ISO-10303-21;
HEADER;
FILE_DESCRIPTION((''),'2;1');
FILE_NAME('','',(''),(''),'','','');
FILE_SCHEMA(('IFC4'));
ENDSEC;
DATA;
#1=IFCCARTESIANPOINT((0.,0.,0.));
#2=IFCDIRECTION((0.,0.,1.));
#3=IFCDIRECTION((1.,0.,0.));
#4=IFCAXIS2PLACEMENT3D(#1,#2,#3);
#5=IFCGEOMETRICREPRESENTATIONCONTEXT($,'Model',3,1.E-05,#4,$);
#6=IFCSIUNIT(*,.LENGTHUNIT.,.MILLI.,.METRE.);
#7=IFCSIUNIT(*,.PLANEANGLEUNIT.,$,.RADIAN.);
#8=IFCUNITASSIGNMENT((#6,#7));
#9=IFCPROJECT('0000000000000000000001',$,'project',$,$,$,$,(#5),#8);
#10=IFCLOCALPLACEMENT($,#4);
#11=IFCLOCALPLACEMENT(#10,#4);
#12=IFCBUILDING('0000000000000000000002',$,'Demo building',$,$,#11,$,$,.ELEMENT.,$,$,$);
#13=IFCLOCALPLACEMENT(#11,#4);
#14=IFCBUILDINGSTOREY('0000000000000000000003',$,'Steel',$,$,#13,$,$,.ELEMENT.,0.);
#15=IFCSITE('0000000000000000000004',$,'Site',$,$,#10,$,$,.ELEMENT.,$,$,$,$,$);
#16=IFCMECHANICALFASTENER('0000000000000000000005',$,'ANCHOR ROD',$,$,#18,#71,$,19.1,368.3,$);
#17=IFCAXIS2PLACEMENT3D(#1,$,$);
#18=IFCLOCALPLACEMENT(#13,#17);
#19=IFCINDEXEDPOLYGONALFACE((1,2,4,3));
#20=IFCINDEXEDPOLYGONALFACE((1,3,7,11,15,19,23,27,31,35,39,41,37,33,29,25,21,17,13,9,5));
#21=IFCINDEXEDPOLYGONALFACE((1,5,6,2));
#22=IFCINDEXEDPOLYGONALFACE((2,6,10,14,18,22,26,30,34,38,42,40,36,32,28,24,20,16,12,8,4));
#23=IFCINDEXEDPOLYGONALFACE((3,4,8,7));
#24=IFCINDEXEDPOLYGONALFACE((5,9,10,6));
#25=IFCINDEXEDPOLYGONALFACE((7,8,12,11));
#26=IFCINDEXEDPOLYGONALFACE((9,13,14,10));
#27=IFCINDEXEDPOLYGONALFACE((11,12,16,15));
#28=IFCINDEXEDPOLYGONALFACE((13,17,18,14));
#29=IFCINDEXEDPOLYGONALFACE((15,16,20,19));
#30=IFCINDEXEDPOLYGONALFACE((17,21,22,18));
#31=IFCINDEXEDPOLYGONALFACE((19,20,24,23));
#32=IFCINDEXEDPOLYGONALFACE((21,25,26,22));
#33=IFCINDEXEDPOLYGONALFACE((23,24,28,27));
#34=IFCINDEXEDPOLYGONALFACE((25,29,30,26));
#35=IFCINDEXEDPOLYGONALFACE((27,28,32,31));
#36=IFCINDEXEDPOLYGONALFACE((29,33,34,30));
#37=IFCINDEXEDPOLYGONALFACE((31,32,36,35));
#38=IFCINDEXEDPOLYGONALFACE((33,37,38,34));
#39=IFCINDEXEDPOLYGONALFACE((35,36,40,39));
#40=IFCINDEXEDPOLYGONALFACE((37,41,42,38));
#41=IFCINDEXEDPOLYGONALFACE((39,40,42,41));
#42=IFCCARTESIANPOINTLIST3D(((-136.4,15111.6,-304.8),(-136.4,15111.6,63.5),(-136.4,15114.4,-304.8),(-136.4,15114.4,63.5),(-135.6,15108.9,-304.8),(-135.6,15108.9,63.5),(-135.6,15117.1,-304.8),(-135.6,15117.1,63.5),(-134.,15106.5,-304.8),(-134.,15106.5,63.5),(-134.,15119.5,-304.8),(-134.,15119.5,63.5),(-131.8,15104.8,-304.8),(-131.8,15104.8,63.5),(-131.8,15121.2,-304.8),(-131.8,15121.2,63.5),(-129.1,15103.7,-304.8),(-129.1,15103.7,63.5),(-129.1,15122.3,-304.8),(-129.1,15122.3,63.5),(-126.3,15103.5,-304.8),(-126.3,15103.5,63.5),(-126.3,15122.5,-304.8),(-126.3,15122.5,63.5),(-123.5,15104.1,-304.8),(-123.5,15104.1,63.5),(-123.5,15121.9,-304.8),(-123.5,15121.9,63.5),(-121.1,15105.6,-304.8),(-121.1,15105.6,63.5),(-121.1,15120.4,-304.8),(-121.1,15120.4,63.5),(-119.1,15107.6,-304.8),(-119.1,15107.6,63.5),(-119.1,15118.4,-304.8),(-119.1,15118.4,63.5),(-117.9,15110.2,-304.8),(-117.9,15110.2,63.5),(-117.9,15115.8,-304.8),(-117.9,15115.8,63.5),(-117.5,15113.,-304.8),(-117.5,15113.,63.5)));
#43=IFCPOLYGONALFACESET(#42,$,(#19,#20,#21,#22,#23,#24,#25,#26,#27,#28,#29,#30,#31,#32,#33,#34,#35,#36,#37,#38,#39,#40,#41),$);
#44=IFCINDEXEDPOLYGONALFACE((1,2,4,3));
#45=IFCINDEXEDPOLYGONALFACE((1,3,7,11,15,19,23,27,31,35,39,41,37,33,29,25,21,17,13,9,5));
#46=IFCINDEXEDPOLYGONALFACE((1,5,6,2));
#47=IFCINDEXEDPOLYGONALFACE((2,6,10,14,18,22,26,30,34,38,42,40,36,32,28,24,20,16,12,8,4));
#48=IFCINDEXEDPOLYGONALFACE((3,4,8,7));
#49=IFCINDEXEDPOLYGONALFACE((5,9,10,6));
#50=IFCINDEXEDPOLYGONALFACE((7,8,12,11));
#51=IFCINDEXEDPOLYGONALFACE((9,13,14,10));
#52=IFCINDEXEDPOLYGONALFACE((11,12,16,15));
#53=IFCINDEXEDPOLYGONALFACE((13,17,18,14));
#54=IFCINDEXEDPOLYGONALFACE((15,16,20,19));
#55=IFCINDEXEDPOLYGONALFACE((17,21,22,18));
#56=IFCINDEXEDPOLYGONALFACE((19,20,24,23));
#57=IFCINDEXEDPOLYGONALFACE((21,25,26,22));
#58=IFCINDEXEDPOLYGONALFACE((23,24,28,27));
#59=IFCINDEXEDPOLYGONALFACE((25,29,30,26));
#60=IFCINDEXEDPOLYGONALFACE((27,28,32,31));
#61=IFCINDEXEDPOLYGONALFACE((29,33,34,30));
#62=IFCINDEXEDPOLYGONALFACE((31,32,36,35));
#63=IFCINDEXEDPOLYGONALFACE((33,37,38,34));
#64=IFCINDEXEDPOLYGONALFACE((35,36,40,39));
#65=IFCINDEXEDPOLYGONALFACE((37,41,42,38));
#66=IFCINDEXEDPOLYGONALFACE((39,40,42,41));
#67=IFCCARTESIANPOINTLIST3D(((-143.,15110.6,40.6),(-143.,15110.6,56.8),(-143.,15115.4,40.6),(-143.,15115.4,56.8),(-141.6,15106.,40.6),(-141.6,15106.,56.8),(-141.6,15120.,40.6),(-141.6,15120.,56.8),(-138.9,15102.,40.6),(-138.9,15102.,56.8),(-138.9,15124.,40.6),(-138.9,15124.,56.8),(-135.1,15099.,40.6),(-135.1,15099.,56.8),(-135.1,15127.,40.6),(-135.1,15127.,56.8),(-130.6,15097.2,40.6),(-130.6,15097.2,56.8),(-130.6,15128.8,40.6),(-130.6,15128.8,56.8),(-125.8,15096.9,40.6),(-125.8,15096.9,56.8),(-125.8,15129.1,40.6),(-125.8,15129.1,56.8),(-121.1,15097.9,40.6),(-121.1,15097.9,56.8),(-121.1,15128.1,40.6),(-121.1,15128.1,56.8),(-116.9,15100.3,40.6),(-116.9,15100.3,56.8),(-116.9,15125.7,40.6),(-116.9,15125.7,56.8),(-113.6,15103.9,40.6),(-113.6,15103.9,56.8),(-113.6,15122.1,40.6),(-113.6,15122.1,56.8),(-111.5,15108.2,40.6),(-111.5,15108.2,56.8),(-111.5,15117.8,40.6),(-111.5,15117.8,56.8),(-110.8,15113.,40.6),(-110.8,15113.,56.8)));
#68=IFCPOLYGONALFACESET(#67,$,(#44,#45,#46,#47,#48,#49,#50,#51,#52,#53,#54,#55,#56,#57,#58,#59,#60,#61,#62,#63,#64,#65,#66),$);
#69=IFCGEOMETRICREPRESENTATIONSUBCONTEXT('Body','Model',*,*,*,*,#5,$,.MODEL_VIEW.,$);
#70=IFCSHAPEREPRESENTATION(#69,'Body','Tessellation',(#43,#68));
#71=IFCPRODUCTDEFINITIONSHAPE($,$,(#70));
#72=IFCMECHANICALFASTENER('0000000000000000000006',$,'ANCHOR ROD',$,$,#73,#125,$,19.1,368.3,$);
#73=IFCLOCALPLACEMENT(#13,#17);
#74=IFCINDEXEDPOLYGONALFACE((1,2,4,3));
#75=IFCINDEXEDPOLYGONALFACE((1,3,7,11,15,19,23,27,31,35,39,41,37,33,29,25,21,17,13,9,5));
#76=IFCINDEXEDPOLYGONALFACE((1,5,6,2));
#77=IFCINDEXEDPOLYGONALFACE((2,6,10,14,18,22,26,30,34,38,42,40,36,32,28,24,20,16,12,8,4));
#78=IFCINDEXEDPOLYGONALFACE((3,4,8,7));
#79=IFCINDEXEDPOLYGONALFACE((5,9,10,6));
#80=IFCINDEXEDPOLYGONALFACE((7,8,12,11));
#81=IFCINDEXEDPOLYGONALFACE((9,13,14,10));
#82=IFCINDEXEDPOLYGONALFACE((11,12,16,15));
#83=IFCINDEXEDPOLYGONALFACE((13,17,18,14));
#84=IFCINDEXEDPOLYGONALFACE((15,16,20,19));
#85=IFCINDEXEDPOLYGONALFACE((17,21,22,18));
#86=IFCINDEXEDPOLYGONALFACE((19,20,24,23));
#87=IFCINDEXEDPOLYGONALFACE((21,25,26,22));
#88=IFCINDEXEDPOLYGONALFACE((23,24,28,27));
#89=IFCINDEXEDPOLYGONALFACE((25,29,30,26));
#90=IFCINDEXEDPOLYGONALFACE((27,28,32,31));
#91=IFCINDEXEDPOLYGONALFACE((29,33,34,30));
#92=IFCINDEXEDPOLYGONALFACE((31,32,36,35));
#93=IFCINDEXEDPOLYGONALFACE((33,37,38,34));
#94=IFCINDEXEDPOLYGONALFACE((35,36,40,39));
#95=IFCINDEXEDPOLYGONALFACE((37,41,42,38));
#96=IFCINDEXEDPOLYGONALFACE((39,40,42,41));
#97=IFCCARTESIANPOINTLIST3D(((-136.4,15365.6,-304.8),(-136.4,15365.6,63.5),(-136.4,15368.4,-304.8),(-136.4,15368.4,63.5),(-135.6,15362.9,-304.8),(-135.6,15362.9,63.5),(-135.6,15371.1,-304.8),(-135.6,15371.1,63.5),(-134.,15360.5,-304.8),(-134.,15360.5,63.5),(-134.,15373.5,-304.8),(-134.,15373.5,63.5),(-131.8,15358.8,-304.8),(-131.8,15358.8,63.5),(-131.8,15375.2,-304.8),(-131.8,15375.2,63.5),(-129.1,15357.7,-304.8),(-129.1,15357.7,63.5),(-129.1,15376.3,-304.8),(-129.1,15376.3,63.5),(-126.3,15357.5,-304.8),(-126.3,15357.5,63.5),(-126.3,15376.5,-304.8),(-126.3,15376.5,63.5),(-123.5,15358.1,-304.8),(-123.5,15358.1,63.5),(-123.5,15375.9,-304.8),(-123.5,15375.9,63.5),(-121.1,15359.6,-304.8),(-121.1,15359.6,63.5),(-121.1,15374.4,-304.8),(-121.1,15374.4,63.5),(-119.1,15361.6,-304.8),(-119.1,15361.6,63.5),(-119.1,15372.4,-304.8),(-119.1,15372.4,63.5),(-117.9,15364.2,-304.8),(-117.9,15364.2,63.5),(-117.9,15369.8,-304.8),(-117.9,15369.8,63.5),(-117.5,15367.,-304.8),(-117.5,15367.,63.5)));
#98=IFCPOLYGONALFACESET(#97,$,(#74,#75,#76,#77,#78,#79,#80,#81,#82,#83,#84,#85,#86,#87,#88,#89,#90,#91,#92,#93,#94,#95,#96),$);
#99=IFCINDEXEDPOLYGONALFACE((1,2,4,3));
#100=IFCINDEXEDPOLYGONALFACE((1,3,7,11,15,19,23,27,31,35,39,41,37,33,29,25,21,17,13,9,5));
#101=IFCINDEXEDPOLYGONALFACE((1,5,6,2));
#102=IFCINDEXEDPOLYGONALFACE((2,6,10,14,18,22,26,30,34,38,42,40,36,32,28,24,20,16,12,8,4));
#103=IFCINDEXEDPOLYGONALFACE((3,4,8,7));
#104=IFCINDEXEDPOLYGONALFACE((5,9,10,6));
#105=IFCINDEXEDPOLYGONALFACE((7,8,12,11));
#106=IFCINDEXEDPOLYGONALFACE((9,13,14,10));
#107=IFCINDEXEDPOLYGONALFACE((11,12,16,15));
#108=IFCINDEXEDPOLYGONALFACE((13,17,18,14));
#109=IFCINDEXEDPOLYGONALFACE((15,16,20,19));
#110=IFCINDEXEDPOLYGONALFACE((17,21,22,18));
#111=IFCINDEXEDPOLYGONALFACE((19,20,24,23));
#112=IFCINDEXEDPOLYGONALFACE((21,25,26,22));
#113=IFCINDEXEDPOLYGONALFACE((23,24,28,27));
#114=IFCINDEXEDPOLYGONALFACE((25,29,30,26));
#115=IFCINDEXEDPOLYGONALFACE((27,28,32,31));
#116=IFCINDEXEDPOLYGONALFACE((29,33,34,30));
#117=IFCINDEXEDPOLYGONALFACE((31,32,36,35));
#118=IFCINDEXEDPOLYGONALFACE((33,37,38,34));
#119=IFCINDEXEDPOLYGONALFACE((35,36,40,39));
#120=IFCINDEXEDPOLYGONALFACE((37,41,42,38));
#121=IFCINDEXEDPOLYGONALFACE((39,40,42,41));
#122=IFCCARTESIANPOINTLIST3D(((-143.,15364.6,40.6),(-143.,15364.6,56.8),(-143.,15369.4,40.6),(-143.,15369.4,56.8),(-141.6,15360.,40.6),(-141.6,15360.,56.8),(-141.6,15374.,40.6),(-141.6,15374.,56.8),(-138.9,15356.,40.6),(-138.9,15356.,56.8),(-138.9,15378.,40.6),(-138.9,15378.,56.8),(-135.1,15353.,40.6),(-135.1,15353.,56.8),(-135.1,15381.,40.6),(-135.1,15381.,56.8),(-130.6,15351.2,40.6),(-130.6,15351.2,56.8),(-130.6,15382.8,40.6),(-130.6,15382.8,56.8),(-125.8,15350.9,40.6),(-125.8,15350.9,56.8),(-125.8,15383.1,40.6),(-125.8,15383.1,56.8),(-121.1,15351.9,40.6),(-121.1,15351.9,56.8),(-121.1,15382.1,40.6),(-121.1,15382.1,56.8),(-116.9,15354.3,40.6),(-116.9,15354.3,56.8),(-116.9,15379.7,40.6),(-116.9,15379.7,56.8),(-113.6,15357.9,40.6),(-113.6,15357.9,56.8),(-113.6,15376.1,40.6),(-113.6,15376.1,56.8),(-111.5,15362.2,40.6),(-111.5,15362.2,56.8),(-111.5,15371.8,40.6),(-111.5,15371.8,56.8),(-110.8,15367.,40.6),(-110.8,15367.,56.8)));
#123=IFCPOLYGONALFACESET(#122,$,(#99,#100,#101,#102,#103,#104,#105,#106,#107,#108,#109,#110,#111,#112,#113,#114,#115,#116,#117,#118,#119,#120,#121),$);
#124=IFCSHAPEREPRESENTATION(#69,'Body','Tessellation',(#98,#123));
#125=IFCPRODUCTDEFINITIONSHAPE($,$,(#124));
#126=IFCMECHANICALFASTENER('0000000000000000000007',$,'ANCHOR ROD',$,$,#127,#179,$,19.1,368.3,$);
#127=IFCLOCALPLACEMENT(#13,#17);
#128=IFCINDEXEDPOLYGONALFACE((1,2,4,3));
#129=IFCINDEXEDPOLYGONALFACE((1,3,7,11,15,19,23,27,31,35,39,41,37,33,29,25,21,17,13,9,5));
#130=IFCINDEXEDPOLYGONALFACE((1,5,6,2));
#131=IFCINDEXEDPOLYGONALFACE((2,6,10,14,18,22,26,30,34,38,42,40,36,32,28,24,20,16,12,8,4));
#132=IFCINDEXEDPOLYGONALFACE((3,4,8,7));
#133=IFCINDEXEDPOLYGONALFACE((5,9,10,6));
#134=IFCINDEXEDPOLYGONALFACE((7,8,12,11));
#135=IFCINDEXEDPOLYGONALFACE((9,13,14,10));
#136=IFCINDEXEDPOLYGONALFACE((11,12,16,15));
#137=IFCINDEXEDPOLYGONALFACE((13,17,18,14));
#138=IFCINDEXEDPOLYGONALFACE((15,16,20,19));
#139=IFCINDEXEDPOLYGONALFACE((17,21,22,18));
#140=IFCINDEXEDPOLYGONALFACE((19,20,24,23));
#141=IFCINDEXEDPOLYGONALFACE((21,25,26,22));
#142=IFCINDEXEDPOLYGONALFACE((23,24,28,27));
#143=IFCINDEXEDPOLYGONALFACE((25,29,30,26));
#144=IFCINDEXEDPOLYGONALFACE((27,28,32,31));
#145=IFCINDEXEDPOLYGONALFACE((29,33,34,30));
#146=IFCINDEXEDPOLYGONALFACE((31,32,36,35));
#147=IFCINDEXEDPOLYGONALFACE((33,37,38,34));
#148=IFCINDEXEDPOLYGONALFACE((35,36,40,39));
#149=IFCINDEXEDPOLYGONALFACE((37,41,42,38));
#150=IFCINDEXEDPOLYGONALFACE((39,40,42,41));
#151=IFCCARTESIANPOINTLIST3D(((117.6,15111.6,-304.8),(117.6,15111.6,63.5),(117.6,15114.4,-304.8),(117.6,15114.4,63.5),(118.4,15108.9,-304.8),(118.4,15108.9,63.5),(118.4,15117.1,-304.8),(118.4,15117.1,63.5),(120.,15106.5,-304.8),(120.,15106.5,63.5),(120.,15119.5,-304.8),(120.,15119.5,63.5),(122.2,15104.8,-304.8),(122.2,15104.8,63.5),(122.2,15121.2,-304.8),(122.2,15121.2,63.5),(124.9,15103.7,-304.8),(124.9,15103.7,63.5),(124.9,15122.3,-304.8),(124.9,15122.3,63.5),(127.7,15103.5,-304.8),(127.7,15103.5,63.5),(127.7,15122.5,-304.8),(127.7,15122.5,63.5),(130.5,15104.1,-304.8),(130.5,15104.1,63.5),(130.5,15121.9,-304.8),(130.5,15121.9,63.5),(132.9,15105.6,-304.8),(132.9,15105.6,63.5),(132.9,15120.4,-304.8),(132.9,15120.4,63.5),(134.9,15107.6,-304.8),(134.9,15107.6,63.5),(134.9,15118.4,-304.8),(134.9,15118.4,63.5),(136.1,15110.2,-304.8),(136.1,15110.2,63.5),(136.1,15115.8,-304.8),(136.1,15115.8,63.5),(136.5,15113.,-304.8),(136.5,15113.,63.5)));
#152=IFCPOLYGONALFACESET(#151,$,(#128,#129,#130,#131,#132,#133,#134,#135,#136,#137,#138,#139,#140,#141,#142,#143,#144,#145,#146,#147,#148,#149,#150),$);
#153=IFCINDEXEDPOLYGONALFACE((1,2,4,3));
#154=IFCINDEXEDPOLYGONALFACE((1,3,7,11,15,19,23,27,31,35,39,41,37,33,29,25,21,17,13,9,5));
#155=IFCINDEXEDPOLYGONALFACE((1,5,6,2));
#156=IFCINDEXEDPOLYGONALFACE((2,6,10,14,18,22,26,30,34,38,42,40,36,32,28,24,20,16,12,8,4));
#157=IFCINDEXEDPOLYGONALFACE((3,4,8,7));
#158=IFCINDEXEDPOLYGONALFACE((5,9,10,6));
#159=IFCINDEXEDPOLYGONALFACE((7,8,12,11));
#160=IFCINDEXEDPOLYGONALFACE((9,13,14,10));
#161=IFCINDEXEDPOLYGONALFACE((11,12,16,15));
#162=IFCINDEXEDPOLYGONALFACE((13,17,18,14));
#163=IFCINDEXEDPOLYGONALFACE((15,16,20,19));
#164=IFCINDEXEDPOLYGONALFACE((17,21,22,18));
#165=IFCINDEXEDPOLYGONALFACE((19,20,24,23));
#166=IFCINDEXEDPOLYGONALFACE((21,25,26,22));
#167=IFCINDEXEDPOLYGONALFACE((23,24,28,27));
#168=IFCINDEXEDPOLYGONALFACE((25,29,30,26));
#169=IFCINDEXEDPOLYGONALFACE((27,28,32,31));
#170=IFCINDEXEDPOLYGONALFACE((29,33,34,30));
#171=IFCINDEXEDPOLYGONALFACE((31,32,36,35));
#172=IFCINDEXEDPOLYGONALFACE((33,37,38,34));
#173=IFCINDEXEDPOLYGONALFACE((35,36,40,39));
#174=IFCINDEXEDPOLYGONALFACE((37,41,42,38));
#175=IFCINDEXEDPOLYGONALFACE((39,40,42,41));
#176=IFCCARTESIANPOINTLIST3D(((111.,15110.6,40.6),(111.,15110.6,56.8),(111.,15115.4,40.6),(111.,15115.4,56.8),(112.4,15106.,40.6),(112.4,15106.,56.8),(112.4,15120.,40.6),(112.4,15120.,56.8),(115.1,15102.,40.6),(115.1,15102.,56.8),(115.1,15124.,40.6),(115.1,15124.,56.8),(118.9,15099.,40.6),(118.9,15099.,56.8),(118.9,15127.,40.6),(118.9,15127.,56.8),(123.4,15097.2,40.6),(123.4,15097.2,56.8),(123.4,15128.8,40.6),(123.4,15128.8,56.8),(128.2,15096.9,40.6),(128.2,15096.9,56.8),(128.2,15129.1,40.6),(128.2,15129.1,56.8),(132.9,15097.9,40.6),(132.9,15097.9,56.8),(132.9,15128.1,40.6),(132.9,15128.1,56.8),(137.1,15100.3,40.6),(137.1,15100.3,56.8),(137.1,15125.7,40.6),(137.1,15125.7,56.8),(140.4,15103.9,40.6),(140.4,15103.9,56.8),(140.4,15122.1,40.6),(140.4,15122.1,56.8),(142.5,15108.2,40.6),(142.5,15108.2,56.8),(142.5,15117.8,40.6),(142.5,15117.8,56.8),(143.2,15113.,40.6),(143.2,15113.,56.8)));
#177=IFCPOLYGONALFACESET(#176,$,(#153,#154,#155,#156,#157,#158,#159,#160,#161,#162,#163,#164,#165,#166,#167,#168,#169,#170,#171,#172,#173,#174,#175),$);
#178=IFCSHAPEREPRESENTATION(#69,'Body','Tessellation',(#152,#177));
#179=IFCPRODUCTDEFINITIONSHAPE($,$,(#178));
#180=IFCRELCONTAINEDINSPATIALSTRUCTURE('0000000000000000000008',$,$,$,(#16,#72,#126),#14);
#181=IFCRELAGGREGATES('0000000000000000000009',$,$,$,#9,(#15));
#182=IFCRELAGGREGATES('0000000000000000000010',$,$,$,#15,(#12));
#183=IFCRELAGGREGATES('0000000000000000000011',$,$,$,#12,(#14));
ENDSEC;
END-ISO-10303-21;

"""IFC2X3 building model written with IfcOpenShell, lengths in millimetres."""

from ifc_helpers import new_model, si_unit, frame, origin, origin_with_axes, origin_2d, place, context, subcontext, project, spatial, circle, extrude, element, save


model = new_model("IFC2X3")

# Units and contexts
model_context = context("Model", 3, precision=1e-05, world=origin_with_axes())
body_context = subcontext(model_context, "Body", "Model", "MODEL_VIEW")
ifc_project = project(units=[si_unit("LENGTHUNIT", "METRE", prefix="MILLI"), si_unit("PLANEANGLEUNIT", "RADIAN")], contexts=[model_context])

# Site, building, storey
site_placement = place(None, origin_with_axes())
site = spatial("IfcSite", under=ifc_project, at=site_placement, Name="Site", CompositionType="ELEMENT")
building_placement = place(site_placement, origin_with_axes())
building = spatial("IfcBuilding", under=site, at=building_placement, Name="Demo building", CompositionType="ELEMENT")
placement = place(building_placement, origin_with_axes())
storey = spatial("IfcBuildingStorey", under=building, at=placement, Name="Steel", CompositionType="ELEMENT", Elevation=0.0)

# Mechanical fasteners
for number, where, z_axis, x_axis, name in (
    (1, (-127.0, 15113.0, -304.8), (0.0, 0.0, 1.0), (1.0, 0.0, 0.0), "ANCHOR ROD"),
    (2, (-127.0, 15367.0, -304.8), (0.0, 0.0, 1.0), (1.0, 0.0, 0.0), "ANCHOR ROD"),
    (3, (127.0, 15113.0, -304.8), (0.0, 0.0, 1.0), (1.0, 0.0, 0.0), "ANCHOR ROD"),
):
    element("IfcMechanicalFastener", number, at=place(placement, frame(where, z_axis=z_axis, x_axis=x_axis)), inside=storey, Name=name, NominalDiameter=19.1, NominalLength=368.3, context=body_context, shape_type="SweptSolid", body=[
        extrude(circle(Radius=9.5, at=origin_2d()), origin(), (0.0, 0.0, 1.0), 368.3),
        extrude(circle(Radius=16.2, at=origin_2d()), frame((0.0, 0.0, 345.4)), (0.0, 0.0, 1.0), 16.2),
    ])

save(model, "model.ifc")
